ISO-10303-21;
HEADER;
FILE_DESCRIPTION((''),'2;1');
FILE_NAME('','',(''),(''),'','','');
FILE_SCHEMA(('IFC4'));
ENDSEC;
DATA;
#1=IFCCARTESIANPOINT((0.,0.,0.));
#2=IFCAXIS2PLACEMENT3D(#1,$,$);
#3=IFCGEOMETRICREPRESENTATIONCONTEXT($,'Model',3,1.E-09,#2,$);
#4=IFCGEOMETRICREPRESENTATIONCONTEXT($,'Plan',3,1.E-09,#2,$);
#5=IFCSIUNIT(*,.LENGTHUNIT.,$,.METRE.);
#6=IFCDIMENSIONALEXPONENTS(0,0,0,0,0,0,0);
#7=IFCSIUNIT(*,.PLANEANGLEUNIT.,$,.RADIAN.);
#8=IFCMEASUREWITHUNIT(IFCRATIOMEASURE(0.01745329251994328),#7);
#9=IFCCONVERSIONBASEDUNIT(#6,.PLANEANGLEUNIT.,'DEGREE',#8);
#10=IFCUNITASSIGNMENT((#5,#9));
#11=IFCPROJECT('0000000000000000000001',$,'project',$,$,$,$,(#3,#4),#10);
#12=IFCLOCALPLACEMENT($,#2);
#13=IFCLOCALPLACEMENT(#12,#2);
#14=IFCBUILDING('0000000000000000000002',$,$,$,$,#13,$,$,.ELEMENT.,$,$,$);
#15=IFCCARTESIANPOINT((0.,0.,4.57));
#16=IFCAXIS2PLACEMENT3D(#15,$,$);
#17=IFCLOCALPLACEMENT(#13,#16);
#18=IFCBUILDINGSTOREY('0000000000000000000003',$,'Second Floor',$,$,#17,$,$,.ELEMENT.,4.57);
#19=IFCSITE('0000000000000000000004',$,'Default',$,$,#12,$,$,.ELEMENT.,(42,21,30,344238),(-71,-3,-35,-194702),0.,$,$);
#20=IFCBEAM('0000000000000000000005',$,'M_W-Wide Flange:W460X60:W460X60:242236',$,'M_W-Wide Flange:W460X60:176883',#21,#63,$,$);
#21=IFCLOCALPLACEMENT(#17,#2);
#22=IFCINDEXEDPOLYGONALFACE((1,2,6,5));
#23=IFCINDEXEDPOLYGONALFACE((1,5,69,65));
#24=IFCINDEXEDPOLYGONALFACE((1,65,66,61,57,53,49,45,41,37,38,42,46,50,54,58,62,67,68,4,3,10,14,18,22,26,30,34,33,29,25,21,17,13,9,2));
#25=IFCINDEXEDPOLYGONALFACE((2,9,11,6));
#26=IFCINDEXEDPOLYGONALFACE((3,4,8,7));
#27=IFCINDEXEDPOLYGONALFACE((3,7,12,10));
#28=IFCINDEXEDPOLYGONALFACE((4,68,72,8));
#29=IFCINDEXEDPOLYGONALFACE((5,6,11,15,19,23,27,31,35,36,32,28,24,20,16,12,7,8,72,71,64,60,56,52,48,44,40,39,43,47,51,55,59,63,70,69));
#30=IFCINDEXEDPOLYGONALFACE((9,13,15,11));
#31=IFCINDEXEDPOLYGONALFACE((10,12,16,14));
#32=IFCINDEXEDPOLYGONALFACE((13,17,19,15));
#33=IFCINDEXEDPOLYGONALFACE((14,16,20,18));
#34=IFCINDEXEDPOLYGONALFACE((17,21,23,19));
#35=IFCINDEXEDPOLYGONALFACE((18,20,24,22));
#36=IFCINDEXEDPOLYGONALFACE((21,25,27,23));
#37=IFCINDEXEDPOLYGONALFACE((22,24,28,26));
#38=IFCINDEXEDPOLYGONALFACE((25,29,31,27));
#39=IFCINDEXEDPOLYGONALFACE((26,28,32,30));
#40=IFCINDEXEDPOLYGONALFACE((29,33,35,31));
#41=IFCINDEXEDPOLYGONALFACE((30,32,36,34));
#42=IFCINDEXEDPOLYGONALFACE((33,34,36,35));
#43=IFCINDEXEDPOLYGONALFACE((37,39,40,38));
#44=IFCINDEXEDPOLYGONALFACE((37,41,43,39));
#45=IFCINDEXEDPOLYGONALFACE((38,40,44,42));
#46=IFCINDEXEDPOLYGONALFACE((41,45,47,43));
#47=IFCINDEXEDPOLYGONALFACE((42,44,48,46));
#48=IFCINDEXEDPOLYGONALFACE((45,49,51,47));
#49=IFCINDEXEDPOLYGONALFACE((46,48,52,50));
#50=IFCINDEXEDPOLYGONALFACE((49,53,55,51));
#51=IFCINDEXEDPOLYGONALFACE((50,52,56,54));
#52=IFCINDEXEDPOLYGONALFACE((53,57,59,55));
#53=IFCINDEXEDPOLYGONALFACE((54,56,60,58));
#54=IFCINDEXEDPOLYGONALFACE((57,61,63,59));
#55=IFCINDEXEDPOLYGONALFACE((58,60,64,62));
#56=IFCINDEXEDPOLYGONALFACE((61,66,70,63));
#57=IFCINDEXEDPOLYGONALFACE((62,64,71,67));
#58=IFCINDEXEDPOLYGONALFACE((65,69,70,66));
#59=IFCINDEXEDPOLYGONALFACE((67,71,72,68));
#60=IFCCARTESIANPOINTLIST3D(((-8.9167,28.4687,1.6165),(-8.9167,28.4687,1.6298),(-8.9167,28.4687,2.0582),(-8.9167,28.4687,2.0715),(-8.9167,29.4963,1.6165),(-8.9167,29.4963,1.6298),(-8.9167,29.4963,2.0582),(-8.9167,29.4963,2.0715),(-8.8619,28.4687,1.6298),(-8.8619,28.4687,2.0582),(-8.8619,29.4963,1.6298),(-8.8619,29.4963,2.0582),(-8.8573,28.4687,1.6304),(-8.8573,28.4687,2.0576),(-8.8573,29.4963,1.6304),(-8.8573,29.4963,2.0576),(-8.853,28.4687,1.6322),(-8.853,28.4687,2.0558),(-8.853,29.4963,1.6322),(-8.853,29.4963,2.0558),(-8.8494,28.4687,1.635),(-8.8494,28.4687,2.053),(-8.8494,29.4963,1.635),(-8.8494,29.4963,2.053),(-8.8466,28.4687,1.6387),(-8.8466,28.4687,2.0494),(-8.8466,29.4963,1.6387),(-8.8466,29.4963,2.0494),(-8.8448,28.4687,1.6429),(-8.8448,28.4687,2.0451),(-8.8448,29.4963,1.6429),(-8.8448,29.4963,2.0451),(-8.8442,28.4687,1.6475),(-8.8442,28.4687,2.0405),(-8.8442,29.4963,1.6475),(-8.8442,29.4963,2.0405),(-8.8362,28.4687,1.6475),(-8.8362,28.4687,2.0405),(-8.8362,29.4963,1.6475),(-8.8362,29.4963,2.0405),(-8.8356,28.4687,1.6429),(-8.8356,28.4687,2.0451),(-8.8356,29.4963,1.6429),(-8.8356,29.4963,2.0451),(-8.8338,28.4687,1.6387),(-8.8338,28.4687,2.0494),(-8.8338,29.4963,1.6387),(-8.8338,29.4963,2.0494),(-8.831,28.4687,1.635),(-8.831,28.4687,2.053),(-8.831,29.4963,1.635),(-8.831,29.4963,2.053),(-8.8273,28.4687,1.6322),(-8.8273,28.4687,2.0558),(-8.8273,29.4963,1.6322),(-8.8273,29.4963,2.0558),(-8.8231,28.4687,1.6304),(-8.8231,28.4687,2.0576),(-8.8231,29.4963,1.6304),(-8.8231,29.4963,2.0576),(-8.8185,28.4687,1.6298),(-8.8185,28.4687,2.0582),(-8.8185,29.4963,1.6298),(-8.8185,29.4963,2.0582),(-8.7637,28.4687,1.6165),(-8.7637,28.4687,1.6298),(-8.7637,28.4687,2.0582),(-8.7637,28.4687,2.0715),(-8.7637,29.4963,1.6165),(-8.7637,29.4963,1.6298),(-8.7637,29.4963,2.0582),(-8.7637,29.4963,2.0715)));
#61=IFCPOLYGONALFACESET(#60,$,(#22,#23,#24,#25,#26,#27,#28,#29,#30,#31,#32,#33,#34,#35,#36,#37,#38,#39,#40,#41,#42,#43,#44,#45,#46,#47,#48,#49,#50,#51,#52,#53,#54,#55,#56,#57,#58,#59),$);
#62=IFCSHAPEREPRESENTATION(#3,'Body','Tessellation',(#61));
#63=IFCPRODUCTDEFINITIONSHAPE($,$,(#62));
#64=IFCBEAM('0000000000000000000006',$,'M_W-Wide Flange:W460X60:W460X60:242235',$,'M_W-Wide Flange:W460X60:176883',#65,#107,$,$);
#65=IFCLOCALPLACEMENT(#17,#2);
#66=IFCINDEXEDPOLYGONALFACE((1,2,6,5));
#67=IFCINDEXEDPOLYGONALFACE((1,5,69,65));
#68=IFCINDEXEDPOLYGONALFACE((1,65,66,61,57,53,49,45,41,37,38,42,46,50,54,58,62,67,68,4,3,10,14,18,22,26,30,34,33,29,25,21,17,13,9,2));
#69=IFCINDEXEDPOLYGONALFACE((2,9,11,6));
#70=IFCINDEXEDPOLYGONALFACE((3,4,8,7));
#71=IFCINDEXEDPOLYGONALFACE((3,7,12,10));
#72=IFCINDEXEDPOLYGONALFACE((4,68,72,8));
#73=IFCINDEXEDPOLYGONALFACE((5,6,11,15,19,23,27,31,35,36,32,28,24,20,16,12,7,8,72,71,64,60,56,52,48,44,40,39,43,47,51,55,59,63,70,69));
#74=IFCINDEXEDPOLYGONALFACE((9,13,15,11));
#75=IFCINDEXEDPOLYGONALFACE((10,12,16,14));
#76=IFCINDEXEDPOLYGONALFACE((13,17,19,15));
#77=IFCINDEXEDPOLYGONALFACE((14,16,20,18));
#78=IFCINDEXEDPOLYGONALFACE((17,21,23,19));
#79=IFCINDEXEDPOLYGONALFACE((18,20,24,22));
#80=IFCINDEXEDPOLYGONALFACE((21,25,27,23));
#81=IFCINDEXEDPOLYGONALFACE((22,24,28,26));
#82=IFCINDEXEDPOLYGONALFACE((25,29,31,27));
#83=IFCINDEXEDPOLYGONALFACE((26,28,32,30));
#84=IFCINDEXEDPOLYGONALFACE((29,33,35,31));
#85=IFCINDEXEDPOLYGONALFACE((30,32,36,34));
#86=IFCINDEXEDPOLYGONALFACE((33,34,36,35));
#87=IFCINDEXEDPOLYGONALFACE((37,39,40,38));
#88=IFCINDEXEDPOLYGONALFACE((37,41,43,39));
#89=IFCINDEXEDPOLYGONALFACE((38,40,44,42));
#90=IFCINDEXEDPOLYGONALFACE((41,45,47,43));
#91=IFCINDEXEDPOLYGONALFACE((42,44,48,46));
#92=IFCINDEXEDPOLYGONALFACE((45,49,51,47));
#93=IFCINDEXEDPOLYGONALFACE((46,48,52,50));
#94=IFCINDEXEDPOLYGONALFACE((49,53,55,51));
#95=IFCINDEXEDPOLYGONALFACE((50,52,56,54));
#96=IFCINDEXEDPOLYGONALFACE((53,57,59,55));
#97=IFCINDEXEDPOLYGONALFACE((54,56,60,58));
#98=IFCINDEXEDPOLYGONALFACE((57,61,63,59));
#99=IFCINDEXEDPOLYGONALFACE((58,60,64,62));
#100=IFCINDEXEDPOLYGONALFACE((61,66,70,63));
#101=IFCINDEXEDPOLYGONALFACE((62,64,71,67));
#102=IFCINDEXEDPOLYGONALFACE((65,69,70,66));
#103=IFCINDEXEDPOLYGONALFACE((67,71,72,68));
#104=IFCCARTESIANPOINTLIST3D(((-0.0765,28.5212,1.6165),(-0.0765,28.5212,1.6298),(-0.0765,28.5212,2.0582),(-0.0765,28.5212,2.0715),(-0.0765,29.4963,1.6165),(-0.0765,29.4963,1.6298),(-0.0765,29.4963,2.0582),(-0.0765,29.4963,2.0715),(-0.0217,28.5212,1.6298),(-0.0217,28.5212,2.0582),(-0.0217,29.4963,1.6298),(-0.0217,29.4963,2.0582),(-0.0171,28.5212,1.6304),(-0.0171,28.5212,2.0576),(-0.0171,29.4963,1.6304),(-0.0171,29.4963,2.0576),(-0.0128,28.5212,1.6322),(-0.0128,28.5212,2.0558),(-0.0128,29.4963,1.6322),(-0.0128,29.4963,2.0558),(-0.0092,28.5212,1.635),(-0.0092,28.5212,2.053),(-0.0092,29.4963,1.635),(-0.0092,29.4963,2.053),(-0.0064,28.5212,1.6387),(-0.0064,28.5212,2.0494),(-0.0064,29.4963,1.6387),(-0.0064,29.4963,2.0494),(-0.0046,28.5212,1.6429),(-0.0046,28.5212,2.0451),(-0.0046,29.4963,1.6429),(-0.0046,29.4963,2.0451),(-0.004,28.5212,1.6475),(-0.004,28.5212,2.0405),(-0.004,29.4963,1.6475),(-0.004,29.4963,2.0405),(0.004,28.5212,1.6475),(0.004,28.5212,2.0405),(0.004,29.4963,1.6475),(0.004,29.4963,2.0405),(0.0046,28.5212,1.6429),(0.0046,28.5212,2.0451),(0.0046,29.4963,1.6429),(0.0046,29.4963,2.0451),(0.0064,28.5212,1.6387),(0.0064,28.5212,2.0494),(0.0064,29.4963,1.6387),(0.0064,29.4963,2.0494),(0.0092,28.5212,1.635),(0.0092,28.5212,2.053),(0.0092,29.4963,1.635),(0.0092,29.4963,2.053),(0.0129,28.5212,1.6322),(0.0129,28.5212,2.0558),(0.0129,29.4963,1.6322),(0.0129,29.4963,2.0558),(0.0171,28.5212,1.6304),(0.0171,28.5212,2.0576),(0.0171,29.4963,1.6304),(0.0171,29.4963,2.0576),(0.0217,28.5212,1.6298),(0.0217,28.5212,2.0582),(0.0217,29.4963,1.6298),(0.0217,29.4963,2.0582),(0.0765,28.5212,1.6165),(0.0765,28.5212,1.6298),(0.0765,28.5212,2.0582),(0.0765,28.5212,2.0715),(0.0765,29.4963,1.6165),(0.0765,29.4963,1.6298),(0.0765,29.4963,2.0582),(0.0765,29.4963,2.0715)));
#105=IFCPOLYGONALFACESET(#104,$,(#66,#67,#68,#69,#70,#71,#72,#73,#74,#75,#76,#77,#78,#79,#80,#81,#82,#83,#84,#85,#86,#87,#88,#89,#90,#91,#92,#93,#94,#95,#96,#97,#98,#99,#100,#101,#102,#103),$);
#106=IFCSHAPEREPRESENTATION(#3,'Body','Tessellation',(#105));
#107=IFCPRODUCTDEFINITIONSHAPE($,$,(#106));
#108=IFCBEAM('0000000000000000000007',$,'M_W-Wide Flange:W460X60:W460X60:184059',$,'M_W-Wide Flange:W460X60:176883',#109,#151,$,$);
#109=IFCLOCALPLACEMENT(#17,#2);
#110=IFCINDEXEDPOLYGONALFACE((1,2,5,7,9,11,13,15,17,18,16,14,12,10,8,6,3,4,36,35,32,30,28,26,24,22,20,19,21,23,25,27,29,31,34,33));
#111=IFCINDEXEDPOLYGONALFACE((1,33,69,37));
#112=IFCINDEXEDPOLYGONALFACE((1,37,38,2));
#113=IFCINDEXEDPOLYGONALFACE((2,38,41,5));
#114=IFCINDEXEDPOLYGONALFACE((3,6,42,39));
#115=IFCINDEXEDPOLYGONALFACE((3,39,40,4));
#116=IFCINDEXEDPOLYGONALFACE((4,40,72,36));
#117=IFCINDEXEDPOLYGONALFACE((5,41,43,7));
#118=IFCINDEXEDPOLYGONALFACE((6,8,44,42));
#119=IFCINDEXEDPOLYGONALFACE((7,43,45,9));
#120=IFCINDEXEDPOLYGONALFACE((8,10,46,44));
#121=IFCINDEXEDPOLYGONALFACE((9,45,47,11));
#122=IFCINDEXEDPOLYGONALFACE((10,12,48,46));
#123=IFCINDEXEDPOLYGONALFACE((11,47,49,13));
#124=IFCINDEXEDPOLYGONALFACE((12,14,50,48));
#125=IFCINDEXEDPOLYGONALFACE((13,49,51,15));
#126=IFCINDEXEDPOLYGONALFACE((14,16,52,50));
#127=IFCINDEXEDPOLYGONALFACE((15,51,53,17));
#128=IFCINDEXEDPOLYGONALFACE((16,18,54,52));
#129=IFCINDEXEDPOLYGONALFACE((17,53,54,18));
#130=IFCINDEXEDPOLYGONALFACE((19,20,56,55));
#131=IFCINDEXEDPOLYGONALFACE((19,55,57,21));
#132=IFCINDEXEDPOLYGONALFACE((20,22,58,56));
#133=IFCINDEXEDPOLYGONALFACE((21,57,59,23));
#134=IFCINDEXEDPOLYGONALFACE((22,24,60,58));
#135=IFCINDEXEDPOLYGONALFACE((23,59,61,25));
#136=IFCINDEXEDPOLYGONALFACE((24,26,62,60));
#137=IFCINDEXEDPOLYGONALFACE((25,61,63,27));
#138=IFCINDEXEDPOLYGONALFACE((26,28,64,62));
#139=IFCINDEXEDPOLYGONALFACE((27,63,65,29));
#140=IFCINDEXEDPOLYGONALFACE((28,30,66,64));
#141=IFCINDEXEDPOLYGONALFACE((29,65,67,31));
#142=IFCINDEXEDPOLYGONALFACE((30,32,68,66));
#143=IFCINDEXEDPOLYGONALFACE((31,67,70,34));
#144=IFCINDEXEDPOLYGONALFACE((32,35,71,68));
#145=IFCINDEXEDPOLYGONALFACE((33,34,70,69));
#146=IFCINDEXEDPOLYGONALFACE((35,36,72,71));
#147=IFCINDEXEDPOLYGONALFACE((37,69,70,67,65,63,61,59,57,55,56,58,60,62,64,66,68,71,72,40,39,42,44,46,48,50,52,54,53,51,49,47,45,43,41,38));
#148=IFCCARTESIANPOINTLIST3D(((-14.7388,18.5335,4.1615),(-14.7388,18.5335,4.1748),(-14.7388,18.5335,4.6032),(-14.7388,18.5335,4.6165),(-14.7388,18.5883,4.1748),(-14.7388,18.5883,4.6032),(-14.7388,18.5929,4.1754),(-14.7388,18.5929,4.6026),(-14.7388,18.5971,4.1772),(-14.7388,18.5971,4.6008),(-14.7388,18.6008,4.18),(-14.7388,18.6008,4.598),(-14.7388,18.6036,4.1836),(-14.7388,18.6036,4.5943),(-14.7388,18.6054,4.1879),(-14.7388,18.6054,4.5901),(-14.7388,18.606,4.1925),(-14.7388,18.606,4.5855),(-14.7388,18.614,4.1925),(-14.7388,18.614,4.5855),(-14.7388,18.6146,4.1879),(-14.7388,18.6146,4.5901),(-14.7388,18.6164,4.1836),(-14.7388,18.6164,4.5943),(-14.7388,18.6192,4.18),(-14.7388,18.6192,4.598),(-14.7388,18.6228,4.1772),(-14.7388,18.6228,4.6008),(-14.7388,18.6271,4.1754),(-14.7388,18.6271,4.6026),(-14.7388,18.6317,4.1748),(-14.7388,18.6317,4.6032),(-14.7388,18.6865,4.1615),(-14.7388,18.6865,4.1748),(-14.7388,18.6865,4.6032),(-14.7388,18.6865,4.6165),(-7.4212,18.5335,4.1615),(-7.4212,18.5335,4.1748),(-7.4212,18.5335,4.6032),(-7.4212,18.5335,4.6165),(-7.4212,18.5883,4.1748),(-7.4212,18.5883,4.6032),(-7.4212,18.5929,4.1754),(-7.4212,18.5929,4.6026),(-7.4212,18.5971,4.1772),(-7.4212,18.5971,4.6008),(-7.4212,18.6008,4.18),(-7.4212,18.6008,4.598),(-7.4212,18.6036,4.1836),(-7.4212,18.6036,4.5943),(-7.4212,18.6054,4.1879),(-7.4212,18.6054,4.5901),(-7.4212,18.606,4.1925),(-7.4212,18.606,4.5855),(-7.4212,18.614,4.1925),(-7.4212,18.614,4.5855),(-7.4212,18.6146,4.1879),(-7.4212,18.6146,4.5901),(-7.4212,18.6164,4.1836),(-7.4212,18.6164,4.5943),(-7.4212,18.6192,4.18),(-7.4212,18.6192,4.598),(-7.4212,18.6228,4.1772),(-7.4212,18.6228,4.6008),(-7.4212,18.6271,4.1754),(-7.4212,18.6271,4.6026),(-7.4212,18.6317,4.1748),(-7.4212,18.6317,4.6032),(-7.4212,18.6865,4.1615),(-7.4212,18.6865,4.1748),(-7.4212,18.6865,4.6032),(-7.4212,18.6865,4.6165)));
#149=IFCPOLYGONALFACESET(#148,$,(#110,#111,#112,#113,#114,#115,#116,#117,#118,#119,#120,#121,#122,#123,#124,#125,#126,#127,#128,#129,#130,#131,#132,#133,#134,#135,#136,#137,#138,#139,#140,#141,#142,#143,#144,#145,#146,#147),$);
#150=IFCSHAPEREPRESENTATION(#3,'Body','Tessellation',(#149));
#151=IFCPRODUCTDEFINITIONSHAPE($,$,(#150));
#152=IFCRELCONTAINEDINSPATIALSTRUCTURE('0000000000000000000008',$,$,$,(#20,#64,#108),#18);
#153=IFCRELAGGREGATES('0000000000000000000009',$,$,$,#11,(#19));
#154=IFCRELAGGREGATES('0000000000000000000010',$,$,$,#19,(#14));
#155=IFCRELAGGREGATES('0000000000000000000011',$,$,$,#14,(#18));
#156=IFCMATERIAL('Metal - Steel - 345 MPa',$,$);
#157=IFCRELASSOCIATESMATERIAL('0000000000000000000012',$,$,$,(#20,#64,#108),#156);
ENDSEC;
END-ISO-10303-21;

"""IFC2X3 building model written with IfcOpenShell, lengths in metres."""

from ifc_helpers import new_model, entity, si_unit, converted_unit, frame, frame_2d, origin, place, context, project, spatial, polyline, circle_curve, parameter, trimmed, segment, composite_curve, outline, extrude, material, element, save


model = new_model("IFC2X3")

# Units and contexts
model_context = context("Model", 3, precision=1e-09, world=origin())
plan_context = context("Plan", 3, precision=1e-09, world=origin())
ifc_project = project(units=[si_unit("LENGTHUNIT", "METRE"), converted_unit("PLANEANGLEUNIT", "DEGREE", entity("IfcRatioMeasure", 0.01745329251994328), si_unit("PLANEANGLEUNIT", "RADIAN"), dimensions=[0, 0, 0, 0, 0, 0, 0])], contexts=[model_context, plan_context])

# Site, building, storey
site_placement = place(None, origin())
site = spatial("IfcSite", under=ifc_project, at=site_placement, Name="Default", CompositionType="ELEMENT", RefLatitude=(42, 21, 30, 344238), RefLongitude=(-71, -3, -35, -194702), RefElevation=0.0)
building_placement = place(site_placement, origin())
building = spatial("IfcBuilding", under=site, at=building_placement, CompositionType="ELEMENT")
storey_placement = place(building_placement, frame((0.0, 0.0, 4.57)))
storey = spatial("IfcBuildingStorey", under=building, at=storey_placement, Name="Second Floor", CompositionType="ELEMENT", Elevation=4.57)

# Shared definitions
ifc_material = material(Name="Metal - Steel - 345 MPa")

# Beams
beam_1_placement = place(storey_placement, frame((-8.8402, 27.4522, 2.0715), z_axis=(0.0, 0.0, 1.0), x_axis=(-1.0, 0.0, 0.0)))
element("IfcBeam", 1, at=beam_1_placement, inside=storey, material=ifc_material, Name="M_W-Wide Flange:W460X60:W460X60:242236", ObjectType="M_W-Wide Flange:W460X60:176883", context=model_context, shape_type="SweptSolid", body=[
    extrude(outline(composite_curve([segment(polyline([(0.2142, -0.0765), (0.2275, -0.0765)]), True, "CONTINUOUS"), segment(polyline([(0.2275, -0.0765), (0.2275, 0.0765)]), True, "CONTINUOUS"), segment(polyline([(0.2275, 0.0765), (0.2142, 0.0765)]), True, "CONTINUOUS"), segment(polyline([(0.2142, 0.0765), (0.2142, 0.0217)]), True, "CONTINUOUS"), segment(trimmed(circle_curve(frame_2d((0.1965, 0.0217), x_axis=(0.0, 1.0)), 0.0177), [parameter(180.0)], [parameter(270.0)], True, "PARAMETER"), False, "CONTINUOUS"), segment(polyline([(0.1965, 0.004), (-0.1965, 0.004)]), True, "CONTINUOUS"), segment(trimmed(circle_curve(frame_2d((-0.1965, 0.0217), x_axis=(0.0, 1.0)), 0.0177), [parameter(90.0)], [parameter(180.0)], True, "PARAMETER"), False, "CONTINUOUS"), segment(polyline([(-0.2142, 0.0217), (-0.2142, 0.0765)]), True, "CONTINUOUS"), segment(polyline([(-0.2142, 0.0765), (-0.2275, 0.0765)]), True, "CONTINUOUS"), segment(polyline([(-0.2275, 0.0765), (-0.2275, -0.0765)]), True, "CONTINUOUS"), segment(polyline([(-0.2275, -0.0765), (-0.2142, -0.0765)]), True, "CONTINUOUS"), segment(polyline([(-0.2142, -0.0765), (-0.2142, -0.0217)]), True, "CONTINUOUS"), segment(trimmed(circle_curve(frame_2d((-0.1965, -0.0217), x_axis=(0.0, 1.0)), 0.0177), [parameter(360.0)], [parameter(90.0)], True, "PARAMETER"), False, "CONTINUOUS"), segment(polyline([(-0.1965, -0.004), (0.1965, -0.004)]), True, "CONTINUOUS"), segment(trimmed(circle_curve(frame_2d((0.1965, -0.0217), x_axis=(0.0, 1.0)), 0.0177), [parameter(270.0)], [parameter(0.0)], True, "PARAMETER"), False, "CONTINUOUS"), segment(polyline([(0.2142, -0.0217), (0.2142, -0.0765)]), True, "CONTINUOUS")], self_intersect=False)), frame((0.0, -1.0165, -0.2275), z_axis=(0.0, -1.0, 0.0), x_axis=(0.0, 0.0, -1.0)), (0.0, 0.0, 1.0), 1.0276),
])
beam_2_placement = place(storey_placement, frame((0.0, 27.4522, 2.0715), z_axis=(0.0, 0.0, 1.0), x_axis=(-1.0, 0.0, 0.0)))
element("IfcBeam", 2, at=beam_2_placement, inside=storey, material=ifc_material, Name="M_W-Wide Flange:W460X60:W460X60:242235", ObjectType="M_W-Wide Flange:W460X60:176883", context=model_context, shape_type="SweptSolid", body=[
    extrude(outline(composite_curve([segment(polyline([(0.2142, -0.0765), (0.2275, -0.0765)]), True, "CONTINUOUS"), segment(polyline([(0.2275, -0.0765), (0.2275, 0.0765)]), True, "CONTINUOUS"), segment(polyline([(0.2275, 0.0765), (0.2142, 0.0765)]), True, "CONTINUOUS"), segment(polyline([(0.2142, 0.0765), (0.2142, 0.0217)]), True, "CONTINUOUS"), segment(trimmed(circle_curve(frame_2d((0.1965, 0.0217), x_axis=(0.0, 1.0)), 0.0177), [parameter(180.0)], [parameter(270.0)], True, "PARAMETER"), False, "CONTINUOUS"), segment(polyline([(0.1965, 0.004), (-0.1965, 0.004)]), True, "CONTINUOUS"), segment(trimmed(circle_curve(frame_2d((-0.1965, 0.0217), x_axis=(0.0, 1.0)), 0.0177), [parameter(90.0)], [parameter(180.0)], True, "PARAMETER"), False, "CONTINUOUS"), segment(polyline([(-0.2142, 0.0217), (-0.2142, 0.0765)]), True, "CONTINUOUS"), segment(polyline([(-0.2142, 0.0765), (-0.2275, 0.0765)]), True, "CONTINUOUS"), segment(polyline([(-0.2275, 0.0765), (-0.2275, -0.0765)]), True, "CONTINUOUS"), segment(polyline([(-0.2275, -0.0765), (-0.2142, -0.0765)]), True, "CONTINUOUS"), segment(polyline([(-0.2142, -0.0765), (-0.2142, -0.0217)]), True, "CONTINUOUS"), segment(trimmed(circle_curve(frame_2d((-0.1965, -0.0217), x_axis=(0.0, 1.0)), 0.0177), [parameter(360.0)], [parameter(90.0)], True, "PARAMETER"), False, "CONTINUOUS"), segment(polyline([(-0.1965, -0.004), (0.1965, -0.004)]), True, "CONTINUOUS"), segment(trimmed(circle_curve(frame_2d((0.1965, -0.0217), x_axis=(0.0, 1.0)), 0.0177), [parameter(270.0)], [parameter(0.0)], True, "PARAMETER"), False, "CONTINUOUS"), segment(polyline([(0.2142, -0.0217), (0.2142, -0.0765)]), True, "CONTINUOUS")], self_intersect=False)), frame((0.0, -1.069, -0.2275), z_axis=(0.0, -1.0, 0.0), x_axis=(0.0, 0.0, -1.0)), (0.0, 0.0, 1.0), 0.9751),
])
beam_3_placement = place(storey_placement, frame((-7.2825, 18.61, 4.6165), z_axis=(0.0, 0.0, 1.0), x_axis=(0.0, 1.0, 0.0)))
element("IfcBeam", 3, at=beam_3_placement, inside=storey, material=ifc_material, Name="M_W-Wide Flange:W460X60:W460X60:184059", ObjectType="M_W-Wide Flange:W460X60:176883", context=model_context, shape_type="SweptSolid", body=[
    extrude(outline(composite_curve([segment(polyline([(0.2142, -0.0765), (0.2275, -0.0765)]), True, "CONTINUOUS"), segment(polyline([(0.2275, -0.0765), (0.2275, 0.0765)]), True, "CONTINUOUS"), segment(polyline([(0.2275, 0.0765), (0.2142, 0.0765)]), True, "CONTINUOUS"), segment(polyline([(0.2142, 0.0765), (0.2142, 0.0217)]), True, "CONTINUOUS"), segment(trimmed(circle_curve(frame_2d((0.1965, 0.0217), x_axis=(1.0, 0.0)), 0.0177), [parameter(270.0)], [parameter(360.0)], True, "PARAMETER"), False, "CONTINUOUS"), segment(polyline([(0.1965, 0.004), (-0.1965, 0.004)]), True, "CONTINUOUS"), segment(trimmed(circle_curve(frame_2d((-0.1965, 0.0217), x_axis=(0.0, -1.0)), 0.0177), [parameter(270.0)], [parameter(360.0)], True, "PARAMETER"), False, "CONTINUOUS"), segment(polyline([(-0.2142, 0.0217), (-0.2142, 0.0765)]), True, "CONTINUOUS"), segment(polyline([(-0.2142, 0.0765), (-0.2275, 0.0765)]), True, "CONTINUOUS"), segment(polyline([(-0.2275, 0.0765), (-0.2275, -0.0765)]), True, "CONTINUOUS"), segment(polyline([(-0.2275, -0.0765), (-0.2142, -0.0765)]), True, "CONTINUOUS"), segment(polyline([(-0.2142, -0.0765), (-0.2142, -0.0217)]), True, "CONTINUOUS"), segment(trimmed(circle_curve(frame_2d((-0.1965, -0.0217), x_axis=(-1.0, 0.0)), 0.0177), [parameter(270.0)], [parameter(360.0)], True, "PARAMETER"), False, "CONTINUOUS"), segment(polyline([(-0.1965, -0.004), (0.1965, -0.004)]), True, "CONTINUOUS"), segment(trimmed(circle_curve(frame_2d((0.1965, -0.0217), x_axis=(0.0, 1.0)), 0.0177), [parameter(270.0)], [parameter(0.0)], True, "PARAMETER"), False, "CONTINUOUS"), segment(polyline([(0.2142, -0.0217), (0.2142, -0.0765)]), True, "CONTINUOUS")], self_intersect=False)), frame((0.0, 7.4563, -0.2275), z_axis=(0.0, -1.0, 0.0), x_axis=(0.0, 0.0, -1.0)), (0.0, 0.0, 1.0), 7.3176),
])

save(model, "model.ifc")
